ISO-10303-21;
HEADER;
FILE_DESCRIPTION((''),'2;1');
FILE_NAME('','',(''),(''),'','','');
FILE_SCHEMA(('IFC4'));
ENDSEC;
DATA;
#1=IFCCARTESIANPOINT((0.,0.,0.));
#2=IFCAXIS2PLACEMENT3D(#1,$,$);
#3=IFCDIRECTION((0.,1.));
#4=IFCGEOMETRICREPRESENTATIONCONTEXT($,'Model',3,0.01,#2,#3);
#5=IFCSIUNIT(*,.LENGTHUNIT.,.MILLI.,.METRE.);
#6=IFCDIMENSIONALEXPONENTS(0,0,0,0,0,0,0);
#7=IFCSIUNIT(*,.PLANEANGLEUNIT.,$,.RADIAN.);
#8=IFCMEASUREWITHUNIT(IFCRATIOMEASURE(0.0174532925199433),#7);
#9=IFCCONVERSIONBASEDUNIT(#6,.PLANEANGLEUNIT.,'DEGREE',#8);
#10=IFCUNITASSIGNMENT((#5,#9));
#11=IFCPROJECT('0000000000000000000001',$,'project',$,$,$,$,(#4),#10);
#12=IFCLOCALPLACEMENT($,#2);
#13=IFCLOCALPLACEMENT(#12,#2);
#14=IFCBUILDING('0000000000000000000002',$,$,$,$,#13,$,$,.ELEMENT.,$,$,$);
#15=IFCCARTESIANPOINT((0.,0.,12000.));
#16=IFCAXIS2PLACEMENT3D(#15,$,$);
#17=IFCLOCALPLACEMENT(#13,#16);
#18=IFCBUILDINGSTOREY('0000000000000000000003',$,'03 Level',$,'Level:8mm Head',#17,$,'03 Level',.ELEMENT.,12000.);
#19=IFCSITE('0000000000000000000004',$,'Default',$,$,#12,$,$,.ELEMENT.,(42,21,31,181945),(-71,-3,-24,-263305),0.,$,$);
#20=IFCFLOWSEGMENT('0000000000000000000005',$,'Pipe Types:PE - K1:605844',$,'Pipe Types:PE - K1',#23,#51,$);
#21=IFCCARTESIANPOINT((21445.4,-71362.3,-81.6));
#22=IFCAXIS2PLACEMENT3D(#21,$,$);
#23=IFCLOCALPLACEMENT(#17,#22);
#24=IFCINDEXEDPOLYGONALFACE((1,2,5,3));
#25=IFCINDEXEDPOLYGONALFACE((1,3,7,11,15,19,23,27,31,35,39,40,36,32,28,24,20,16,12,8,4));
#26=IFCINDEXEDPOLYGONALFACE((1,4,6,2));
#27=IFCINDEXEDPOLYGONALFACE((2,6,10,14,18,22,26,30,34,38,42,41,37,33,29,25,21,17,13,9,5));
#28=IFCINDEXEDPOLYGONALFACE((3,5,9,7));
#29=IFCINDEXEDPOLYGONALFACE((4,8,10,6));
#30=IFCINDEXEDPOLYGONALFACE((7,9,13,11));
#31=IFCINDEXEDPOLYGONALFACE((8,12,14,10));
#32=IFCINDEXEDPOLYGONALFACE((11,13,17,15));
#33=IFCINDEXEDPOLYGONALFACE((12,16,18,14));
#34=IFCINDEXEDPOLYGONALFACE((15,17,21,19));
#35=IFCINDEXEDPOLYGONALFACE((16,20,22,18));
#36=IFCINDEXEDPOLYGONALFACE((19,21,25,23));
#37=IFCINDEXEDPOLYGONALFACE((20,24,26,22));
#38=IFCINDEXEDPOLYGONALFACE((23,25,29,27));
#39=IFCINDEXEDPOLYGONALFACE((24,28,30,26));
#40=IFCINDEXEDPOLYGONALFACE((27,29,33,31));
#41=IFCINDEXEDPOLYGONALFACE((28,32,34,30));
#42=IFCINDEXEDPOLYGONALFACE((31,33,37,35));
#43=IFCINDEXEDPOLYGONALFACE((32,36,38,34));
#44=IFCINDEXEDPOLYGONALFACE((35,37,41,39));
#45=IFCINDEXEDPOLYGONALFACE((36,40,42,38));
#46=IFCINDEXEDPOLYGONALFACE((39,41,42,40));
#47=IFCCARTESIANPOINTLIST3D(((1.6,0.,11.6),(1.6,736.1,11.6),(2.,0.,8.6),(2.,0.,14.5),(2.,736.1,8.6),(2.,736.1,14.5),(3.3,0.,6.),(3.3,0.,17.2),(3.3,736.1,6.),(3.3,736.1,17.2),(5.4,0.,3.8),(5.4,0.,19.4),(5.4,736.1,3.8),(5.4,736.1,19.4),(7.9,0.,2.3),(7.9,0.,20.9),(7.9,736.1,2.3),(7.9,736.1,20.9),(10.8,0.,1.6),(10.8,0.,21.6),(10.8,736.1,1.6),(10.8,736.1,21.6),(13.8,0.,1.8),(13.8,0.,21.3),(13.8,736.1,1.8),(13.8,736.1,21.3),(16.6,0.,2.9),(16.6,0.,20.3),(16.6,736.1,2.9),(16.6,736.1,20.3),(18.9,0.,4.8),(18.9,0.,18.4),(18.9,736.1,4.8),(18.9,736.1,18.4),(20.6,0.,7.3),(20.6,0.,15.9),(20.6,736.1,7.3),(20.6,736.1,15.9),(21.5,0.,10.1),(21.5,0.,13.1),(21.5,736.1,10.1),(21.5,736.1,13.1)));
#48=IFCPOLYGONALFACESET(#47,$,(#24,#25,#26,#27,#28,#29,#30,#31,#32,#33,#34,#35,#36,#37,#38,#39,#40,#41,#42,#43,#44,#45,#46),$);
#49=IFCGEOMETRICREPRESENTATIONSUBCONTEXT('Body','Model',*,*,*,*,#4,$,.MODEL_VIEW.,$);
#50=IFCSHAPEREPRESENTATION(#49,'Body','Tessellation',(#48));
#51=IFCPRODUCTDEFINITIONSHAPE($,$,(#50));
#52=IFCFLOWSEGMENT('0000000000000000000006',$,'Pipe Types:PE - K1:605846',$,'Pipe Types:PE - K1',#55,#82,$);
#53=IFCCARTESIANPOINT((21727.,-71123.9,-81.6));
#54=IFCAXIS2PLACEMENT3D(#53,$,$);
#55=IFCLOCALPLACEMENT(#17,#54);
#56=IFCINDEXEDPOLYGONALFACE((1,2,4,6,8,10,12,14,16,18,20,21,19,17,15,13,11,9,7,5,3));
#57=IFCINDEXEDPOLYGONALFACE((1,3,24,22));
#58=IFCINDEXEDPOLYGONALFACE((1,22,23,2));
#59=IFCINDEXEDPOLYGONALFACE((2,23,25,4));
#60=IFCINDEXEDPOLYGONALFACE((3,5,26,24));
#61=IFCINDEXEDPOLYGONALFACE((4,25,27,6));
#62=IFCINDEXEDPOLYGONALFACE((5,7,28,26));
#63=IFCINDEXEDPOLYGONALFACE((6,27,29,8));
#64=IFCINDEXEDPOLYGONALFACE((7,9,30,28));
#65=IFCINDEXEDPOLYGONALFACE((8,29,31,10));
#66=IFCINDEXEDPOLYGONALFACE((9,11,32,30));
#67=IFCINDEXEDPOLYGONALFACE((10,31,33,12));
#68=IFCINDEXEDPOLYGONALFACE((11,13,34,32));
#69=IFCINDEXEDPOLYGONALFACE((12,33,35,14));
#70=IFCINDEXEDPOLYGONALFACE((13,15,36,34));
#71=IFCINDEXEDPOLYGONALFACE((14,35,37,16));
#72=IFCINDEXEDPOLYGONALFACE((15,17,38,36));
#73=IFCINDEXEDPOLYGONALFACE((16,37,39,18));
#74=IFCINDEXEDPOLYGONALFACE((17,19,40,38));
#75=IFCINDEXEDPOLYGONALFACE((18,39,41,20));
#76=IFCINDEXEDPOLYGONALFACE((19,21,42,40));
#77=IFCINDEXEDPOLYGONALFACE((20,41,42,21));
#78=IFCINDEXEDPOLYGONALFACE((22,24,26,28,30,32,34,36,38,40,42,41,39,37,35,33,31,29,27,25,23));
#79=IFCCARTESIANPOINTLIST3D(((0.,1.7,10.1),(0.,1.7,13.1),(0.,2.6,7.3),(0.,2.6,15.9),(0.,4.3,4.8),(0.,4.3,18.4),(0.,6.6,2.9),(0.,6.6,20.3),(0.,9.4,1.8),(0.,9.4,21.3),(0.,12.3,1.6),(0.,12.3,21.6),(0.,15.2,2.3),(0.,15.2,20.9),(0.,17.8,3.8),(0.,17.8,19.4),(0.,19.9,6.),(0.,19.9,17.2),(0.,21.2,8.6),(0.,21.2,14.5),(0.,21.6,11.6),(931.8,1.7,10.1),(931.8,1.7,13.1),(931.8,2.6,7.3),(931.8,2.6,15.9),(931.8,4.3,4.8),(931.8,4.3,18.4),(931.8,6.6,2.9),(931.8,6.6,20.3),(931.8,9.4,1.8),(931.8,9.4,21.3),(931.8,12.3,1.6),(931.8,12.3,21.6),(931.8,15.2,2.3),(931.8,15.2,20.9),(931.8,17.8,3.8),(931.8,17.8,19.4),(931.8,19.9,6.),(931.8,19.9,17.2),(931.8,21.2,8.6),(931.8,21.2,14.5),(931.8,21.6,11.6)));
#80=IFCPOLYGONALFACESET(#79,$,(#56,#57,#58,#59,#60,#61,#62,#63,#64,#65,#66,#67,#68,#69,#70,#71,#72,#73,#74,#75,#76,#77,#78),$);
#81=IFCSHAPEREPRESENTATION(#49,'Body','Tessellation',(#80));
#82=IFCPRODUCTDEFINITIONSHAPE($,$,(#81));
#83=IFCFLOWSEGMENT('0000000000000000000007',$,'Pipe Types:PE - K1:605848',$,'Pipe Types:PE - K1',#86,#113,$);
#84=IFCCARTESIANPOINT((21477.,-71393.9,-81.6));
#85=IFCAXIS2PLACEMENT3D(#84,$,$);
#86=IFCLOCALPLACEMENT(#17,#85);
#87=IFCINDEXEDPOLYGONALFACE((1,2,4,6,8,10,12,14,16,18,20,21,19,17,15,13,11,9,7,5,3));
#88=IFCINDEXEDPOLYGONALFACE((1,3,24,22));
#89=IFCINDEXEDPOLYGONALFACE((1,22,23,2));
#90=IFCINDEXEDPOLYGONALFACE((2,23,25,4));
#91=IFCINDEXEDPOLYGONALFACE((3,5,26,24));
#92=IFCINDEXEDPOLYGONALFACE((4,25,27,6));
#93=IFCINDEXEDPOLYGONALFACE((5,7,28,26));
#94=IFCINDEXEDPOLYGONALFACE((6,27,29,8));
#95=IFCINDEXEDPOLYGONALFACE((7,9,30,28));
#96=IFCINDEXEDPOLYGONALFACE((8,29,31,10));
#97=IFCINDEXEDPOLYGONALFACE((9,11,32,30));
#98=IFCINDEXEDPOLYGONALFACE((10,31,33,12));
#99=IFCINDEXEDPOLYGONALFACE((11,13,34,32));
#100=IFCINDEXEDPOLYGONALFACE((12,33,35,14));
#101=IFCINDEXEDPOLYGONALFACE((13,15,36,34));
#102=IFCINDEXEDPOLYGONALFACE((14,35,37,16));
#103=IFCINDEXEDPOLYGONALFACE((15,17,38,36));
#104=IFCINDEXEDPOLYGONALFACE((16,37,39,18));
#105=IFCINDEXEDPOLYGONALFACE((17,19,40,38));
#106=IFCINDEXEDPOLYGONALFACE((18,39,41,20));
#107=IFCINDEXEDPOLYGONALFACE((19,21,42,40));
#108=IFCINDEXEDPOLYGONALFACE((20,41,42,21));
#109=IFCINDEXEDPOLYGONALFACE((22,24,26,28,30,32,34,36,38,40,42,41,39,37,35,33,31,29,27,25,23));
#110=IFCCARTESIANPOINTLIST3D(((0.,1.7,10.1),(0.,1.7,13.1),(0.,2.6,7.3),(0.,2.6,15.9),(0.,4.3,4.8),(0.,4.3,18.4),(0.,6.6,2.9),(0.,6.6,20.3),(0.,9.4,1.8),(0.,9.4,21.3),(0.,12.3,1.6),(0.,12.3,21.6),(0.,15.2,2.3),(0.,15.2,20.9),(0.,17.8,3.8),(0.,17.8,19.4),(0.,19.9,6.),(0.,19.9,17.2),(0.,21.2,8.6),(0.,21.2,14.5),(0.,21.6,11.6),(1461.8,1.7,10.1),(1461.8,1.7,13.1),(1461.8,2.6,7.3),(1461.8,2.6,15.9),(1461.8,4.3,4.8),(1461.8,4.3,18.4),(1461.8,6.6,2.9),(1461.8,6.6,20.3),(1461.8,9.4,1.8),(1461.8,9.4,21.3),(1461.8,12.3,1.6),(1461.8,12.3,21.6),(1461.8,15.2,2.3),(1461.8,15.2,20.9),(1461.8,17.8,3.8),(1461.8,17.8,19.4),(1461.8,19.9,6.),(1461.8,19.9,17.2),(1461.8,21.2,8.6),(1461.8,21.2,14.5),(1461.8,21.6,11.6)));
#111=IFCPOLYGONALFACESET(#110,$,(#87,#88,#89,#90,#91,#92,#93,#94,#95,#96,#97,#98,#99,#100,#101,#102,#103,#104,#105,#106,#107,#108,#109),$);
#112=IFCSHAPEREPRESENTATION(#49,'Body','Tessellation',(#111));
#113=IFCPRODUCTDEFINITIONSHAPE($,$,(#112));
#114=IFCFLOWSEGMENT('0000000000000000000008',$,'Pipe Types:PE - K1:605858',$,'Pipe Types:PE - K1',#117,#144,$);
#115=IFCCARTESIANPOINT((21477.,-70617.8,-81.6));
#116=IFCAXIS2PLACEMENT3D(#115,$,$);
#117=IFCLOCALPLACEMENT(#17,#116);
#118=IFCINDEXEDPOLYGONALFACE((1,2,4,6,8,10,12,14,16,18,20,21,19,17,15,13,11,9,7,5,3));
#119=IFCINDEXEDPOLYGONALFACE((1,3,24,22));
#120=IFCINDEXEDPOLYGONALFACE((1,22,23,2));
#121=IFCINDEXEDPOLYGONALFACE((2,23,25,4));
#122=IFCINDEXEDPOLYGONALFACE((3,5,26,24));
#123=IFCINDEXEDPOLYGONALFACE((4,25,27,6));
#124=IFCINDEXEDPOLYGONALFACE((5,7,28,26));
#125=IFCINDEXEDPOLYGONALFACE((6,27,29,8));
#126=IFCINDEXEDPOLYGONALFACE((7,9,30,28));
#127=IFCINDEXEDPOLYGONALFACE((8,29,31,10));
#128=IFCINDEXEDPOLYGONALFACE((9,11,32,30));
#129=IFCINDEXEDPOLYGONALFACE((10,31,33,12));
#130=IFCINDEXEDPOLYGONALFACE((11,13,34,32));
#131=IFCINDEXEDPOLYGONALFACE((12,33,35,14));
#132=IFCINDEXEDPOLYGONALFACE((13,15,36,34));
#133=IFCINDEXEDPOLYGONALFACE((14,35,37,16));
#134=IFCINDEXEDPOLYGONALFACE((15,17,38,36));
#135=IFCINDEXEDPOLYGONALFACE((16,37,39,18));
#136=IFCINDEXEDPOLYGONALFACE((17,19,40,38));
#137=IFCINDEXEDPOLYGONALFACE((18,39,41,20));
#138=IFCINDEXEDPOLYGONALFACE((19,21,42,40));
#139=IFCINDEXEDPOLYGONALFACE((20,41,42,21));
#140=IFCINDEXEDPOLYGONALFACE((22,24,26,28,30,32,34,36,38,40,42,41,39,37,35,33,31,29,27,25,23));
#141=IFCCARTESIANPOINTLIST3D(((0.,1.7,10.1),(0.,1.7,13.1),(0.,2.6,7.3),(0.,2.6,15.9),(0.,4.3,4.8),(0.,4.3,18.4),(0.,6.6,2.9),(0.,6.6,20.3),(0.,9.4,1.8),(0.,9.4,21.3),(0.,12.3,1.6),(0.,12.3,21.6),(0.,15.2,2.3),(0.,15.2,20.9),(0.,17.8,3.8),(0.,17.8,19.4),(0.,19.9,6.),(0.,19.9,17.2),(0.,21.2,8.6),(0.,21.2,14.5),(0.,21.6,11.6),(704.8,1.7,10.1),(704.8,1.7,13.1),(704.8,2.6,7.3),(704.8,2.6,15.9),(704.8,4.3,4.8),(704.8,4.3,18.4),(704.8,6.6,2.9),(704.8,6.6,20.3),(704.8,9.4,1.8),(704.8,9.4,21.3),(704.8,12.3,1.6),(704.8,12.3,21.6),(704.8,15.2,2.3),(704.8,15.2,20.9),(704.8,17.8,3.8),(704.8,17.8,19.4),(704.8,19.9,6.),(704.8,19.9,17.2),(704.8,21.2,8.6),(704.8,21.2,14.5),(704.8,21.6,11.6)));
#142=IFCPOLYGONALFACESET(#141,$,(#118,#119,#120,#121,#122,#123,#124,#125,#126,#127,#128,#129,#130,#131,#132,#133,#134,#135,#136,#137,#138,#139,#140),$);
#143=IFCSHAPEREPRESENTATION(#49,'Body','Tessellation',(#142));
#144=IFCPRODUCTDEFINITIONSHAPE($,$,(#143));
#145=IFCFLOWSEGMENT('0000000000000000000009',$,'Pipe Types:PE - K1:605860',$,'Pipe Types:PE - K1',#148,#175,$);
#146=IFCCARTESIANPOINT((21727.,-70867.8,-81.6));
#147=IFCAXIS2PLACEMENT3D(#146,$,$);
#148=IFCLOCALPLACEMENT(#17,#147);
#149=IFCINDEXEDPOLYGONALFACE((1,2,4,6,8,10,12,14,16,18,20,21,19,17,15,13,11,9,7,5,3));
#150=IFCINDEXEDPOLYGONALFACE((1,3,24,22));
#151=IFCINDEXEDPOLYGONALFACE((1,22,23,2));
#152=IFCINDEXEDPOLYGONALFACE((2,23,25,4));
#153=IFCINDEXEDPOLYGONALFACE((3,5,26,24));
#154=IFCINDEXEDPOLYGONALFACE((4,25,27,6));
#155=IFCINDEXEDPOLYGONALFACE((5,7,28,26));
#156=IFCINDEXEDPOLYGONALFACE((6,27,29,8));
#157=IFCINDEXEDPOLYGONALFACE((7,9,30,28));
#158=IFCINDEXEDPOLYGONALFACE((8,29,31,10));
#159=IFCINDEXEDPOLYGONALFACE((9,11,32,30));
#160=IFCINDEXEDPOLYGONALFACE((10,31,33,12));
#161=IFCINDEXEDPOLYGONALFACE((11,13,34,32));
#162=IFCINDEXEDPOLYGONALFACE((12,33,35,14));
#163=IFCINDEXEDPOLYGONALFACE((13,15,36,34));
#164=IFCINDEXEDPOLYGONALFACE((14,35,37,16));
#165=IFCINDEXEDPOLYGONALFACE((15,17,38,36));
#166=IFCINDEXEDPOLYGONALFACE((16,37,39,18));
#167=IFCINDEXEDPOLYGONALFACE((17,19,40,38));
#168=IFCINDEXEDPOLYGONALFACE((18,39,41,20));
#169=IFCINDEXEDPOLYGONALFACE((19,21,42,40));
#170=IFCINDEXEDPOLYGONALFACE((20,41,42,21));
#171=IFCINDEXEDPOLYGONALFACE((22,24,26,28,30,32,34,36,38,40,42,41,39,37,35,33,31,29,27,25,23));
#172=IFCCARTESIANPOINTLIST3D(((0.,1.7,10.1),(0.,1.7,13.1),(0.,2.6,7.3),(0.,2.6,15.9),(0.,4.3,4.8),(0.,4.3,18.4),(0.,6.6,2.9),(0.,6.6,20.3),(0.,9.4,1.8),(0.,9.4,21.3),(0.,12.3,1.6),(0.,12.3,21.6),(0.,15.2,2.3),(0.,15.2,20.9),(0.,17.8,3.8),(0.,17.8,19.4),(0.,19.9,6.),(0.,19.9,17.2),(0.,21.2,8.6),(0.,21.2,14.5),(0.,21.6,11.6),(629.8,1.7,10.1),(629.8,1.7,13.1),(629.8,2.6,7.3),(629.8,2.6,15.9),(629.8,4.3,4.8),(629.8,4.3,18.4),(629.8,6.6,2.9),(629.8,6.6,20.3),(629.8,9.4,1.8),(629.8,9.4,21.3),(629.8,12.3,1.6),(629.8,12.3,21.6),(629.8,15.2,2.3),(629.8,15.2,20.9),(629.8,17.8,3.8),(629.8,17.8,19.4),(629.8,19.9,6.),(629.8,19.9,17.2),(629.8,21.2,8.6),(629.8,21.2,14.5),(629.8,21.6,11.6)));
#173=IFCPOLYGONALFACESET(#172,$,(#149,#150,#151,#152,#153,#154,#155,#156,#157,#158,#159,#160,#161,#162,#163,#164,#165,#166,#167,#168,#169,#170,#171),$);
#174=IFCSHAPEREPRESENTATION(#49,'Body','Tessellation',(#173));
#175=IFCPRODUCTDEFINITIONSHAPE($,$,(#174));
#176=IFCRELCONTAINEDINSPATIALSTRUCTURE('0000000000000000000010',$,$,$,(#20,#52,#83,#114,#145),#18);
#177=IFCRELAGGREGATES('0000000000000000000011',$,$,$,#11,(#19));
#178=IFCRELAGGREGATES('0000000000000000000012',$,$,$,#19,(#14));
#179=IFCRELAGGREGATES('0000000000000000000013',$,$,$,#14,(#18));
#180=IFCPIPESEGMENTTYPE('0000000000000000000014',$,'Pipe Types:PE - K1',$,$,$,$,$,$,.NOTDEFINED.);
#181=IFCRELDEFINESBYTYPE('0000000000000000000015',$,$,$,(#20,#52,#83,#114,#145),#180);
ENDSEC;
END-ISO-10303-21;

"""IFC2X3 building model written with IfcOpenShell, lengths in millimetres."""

from ifc_helpers import new_model, entity, si_unit, converted_unit, direction, frame, frame_2d, origin, origin_2d_with_axis, place, context, subcontext, project, spatial, circle, extrude, type_object, element, save


model = new_model("IFC2X3")

# Units and contexts
model_context = context("Model", 3, precision=0.01, world=origin(), true_north=direction((0.0, 1.0)))
body_context = subcontext(model_context, "Body", "Model", "MODEL_VIEW")
ifc_project = project(units=[si_unit("LENGTHUNIT", "METRE", prefix="MILLI"), converted_unit("PLANEANGLEUNIT", "DEGREE", entity("IfcRatioMeasure", 0.0174532925199433), si_unit("PLANEANGLEUNIT", "RADIAN"), dimensions=[0, 0, 0, 0, 0, 0, 0])], contexts=[model_context])

# Site, building, storey
site_placement = place(None, origin())
site = spatial("IfcSite", under=ifc_project, at=site_placement, Name="Default", CompositionType="ELEMENT", RefLatitude=(42, 21, 31, 181945), RefLongitude=(-71, -3, -24, -263305), RefElevation=0.0)
building_placement = place(site_placement, origin())
building = spatial("IfcBuilding", under=site, at=building_placement, CompositionType="ELEMENT")
storey_placement = place(building_placement, frame((0.0, 0.0, 12000.0)))
storey = spatial("IfcBuildingStorey", under=building, at=storey_placement, Name="03 Level", ObjectType="Level:8mm Head", LongName="03 Level", CompositionType="ELEMENT", Elevation=12000.0)

# Flow segments
pipe_segment_type = type_object("IfcPipeSegmentType", Name="Pipe Types:PE - K1", PredefinedType="NOTDEFINED")
flow_segment_1_placement = place(storey_placement, frame((21445.4, -71362.3, -81.6)))
element("IfcFlowSegment", 1, at=flow_segment_1_placement, inside=storey, type_object=pipe_segment_type, Name="Pipe Types:PE - K1:605844", ObjectType="Pipe Types:PE - K1", context=body_context, shape_type="SweptSolid", body=[
    extrude(circle(Radius=10.0, at=frame_2d((0.0, 0.0), x_axis=(1.0, 0.0))), frame((11.6, 0.0, 11.6), z_axis=(0.0, 1.0, 0.0), x_axis=(-1.0, 0.0, 0.0)), (0.0, 0.0, 1.0), 736.1),
])
flow_segment_2_placement = place(storey_placement, frame((21727.0, -71123.9, -81.6)))
element("IfcFlowSegment", 2, at=flow_segment_2_placement, inside=storey, type_object=pipe_segment_type, Name="Pipe Types:PE - K1:605846", ObjectType="Pipe Types:PE - K1", context=body_context, shape_type="SweptSolid", body=[
    extrude(circle(Radius=10.0, at=frame_2d((0.0, 0.0), x_axis=(1.0, 0.0))), frame((0.0, 11.6, 11.6), z_axis=(1.0, 0.0, 0.0), x_axis=(0.0, 1.0, 0.0)), (0.0, 0.0, 1.0), 931.8),
])
flow_segment_3_placement = place(storey_placement, frame((21477.0, -71393.9, -81.6)))
element("IfcFlowSegment", 3, at=flow_segment_3_placement, inside=storey, type_object=pipe_segment_type, Name="Pipe Types:PE - K1:605848", ObjectType="Pipe Types:PE - K1", context=body_context, shape_type="SweptSolid", body=[
    extrude(circle(Radius=10.0, at=origin_2d_with_axis()), frame((0.0, 11.6, 11.6), z_axis=(1.0, 0.0, 0.0), x_axis=(0.0, 1.0, 0.0)), (0.0, 0.0, 1.0), 1461.8),
])
flow_segment_4_placement = place(storey_placement, frame((21477.0, -70617.8, -81.6)))
element("IfcFlowSegment", 4, at=flow_segment_4_placement, inside=storey, type_object=pipe_segment_type, Name="Pipe Types:PE - K1:605858", ObjectType="Pipe Types:PE - K1", context=body_context, shape_type="SweptSolid", body=[
    extrude(circle(Radius=10.0, at=frame_2d((0.0, 0.0), x_axis=(1.0, 0.0))), frame((0.0, 11.6, 11.6), z_axis=(1.0, 0.0, 0.0), x_axis=(0.0, 1.0, 0.0)), (0.0, 0.0, 1.0), 704.8),
])
flow_segment_5_placement = place(storey_placement, frame((21727.0, -70867.8, -81.6)))
element("IfcFlowSegment", 5, at=flow_segment_5_placement, inside=storey, type_object=pipe_segment_type, Name="Pipe Types:PE - K1:605860", ObjectType="Pipe Types:PE - K1", context=body_context, shape_type="SweptSolid", body=[
    extrude(circle(Radius=10.0, at=frame_2d((0.0, 0.0), x_axis=(1.0, 0.0))), frame((0.0, 11.6, 11.6), z_axis=(1.0, 0.0, 0.0), x_axis=(0.0, 1.0, 0.0)), (0.0, 0.0, 1.0), 629.8),
])

save(model, "model.ifc")
